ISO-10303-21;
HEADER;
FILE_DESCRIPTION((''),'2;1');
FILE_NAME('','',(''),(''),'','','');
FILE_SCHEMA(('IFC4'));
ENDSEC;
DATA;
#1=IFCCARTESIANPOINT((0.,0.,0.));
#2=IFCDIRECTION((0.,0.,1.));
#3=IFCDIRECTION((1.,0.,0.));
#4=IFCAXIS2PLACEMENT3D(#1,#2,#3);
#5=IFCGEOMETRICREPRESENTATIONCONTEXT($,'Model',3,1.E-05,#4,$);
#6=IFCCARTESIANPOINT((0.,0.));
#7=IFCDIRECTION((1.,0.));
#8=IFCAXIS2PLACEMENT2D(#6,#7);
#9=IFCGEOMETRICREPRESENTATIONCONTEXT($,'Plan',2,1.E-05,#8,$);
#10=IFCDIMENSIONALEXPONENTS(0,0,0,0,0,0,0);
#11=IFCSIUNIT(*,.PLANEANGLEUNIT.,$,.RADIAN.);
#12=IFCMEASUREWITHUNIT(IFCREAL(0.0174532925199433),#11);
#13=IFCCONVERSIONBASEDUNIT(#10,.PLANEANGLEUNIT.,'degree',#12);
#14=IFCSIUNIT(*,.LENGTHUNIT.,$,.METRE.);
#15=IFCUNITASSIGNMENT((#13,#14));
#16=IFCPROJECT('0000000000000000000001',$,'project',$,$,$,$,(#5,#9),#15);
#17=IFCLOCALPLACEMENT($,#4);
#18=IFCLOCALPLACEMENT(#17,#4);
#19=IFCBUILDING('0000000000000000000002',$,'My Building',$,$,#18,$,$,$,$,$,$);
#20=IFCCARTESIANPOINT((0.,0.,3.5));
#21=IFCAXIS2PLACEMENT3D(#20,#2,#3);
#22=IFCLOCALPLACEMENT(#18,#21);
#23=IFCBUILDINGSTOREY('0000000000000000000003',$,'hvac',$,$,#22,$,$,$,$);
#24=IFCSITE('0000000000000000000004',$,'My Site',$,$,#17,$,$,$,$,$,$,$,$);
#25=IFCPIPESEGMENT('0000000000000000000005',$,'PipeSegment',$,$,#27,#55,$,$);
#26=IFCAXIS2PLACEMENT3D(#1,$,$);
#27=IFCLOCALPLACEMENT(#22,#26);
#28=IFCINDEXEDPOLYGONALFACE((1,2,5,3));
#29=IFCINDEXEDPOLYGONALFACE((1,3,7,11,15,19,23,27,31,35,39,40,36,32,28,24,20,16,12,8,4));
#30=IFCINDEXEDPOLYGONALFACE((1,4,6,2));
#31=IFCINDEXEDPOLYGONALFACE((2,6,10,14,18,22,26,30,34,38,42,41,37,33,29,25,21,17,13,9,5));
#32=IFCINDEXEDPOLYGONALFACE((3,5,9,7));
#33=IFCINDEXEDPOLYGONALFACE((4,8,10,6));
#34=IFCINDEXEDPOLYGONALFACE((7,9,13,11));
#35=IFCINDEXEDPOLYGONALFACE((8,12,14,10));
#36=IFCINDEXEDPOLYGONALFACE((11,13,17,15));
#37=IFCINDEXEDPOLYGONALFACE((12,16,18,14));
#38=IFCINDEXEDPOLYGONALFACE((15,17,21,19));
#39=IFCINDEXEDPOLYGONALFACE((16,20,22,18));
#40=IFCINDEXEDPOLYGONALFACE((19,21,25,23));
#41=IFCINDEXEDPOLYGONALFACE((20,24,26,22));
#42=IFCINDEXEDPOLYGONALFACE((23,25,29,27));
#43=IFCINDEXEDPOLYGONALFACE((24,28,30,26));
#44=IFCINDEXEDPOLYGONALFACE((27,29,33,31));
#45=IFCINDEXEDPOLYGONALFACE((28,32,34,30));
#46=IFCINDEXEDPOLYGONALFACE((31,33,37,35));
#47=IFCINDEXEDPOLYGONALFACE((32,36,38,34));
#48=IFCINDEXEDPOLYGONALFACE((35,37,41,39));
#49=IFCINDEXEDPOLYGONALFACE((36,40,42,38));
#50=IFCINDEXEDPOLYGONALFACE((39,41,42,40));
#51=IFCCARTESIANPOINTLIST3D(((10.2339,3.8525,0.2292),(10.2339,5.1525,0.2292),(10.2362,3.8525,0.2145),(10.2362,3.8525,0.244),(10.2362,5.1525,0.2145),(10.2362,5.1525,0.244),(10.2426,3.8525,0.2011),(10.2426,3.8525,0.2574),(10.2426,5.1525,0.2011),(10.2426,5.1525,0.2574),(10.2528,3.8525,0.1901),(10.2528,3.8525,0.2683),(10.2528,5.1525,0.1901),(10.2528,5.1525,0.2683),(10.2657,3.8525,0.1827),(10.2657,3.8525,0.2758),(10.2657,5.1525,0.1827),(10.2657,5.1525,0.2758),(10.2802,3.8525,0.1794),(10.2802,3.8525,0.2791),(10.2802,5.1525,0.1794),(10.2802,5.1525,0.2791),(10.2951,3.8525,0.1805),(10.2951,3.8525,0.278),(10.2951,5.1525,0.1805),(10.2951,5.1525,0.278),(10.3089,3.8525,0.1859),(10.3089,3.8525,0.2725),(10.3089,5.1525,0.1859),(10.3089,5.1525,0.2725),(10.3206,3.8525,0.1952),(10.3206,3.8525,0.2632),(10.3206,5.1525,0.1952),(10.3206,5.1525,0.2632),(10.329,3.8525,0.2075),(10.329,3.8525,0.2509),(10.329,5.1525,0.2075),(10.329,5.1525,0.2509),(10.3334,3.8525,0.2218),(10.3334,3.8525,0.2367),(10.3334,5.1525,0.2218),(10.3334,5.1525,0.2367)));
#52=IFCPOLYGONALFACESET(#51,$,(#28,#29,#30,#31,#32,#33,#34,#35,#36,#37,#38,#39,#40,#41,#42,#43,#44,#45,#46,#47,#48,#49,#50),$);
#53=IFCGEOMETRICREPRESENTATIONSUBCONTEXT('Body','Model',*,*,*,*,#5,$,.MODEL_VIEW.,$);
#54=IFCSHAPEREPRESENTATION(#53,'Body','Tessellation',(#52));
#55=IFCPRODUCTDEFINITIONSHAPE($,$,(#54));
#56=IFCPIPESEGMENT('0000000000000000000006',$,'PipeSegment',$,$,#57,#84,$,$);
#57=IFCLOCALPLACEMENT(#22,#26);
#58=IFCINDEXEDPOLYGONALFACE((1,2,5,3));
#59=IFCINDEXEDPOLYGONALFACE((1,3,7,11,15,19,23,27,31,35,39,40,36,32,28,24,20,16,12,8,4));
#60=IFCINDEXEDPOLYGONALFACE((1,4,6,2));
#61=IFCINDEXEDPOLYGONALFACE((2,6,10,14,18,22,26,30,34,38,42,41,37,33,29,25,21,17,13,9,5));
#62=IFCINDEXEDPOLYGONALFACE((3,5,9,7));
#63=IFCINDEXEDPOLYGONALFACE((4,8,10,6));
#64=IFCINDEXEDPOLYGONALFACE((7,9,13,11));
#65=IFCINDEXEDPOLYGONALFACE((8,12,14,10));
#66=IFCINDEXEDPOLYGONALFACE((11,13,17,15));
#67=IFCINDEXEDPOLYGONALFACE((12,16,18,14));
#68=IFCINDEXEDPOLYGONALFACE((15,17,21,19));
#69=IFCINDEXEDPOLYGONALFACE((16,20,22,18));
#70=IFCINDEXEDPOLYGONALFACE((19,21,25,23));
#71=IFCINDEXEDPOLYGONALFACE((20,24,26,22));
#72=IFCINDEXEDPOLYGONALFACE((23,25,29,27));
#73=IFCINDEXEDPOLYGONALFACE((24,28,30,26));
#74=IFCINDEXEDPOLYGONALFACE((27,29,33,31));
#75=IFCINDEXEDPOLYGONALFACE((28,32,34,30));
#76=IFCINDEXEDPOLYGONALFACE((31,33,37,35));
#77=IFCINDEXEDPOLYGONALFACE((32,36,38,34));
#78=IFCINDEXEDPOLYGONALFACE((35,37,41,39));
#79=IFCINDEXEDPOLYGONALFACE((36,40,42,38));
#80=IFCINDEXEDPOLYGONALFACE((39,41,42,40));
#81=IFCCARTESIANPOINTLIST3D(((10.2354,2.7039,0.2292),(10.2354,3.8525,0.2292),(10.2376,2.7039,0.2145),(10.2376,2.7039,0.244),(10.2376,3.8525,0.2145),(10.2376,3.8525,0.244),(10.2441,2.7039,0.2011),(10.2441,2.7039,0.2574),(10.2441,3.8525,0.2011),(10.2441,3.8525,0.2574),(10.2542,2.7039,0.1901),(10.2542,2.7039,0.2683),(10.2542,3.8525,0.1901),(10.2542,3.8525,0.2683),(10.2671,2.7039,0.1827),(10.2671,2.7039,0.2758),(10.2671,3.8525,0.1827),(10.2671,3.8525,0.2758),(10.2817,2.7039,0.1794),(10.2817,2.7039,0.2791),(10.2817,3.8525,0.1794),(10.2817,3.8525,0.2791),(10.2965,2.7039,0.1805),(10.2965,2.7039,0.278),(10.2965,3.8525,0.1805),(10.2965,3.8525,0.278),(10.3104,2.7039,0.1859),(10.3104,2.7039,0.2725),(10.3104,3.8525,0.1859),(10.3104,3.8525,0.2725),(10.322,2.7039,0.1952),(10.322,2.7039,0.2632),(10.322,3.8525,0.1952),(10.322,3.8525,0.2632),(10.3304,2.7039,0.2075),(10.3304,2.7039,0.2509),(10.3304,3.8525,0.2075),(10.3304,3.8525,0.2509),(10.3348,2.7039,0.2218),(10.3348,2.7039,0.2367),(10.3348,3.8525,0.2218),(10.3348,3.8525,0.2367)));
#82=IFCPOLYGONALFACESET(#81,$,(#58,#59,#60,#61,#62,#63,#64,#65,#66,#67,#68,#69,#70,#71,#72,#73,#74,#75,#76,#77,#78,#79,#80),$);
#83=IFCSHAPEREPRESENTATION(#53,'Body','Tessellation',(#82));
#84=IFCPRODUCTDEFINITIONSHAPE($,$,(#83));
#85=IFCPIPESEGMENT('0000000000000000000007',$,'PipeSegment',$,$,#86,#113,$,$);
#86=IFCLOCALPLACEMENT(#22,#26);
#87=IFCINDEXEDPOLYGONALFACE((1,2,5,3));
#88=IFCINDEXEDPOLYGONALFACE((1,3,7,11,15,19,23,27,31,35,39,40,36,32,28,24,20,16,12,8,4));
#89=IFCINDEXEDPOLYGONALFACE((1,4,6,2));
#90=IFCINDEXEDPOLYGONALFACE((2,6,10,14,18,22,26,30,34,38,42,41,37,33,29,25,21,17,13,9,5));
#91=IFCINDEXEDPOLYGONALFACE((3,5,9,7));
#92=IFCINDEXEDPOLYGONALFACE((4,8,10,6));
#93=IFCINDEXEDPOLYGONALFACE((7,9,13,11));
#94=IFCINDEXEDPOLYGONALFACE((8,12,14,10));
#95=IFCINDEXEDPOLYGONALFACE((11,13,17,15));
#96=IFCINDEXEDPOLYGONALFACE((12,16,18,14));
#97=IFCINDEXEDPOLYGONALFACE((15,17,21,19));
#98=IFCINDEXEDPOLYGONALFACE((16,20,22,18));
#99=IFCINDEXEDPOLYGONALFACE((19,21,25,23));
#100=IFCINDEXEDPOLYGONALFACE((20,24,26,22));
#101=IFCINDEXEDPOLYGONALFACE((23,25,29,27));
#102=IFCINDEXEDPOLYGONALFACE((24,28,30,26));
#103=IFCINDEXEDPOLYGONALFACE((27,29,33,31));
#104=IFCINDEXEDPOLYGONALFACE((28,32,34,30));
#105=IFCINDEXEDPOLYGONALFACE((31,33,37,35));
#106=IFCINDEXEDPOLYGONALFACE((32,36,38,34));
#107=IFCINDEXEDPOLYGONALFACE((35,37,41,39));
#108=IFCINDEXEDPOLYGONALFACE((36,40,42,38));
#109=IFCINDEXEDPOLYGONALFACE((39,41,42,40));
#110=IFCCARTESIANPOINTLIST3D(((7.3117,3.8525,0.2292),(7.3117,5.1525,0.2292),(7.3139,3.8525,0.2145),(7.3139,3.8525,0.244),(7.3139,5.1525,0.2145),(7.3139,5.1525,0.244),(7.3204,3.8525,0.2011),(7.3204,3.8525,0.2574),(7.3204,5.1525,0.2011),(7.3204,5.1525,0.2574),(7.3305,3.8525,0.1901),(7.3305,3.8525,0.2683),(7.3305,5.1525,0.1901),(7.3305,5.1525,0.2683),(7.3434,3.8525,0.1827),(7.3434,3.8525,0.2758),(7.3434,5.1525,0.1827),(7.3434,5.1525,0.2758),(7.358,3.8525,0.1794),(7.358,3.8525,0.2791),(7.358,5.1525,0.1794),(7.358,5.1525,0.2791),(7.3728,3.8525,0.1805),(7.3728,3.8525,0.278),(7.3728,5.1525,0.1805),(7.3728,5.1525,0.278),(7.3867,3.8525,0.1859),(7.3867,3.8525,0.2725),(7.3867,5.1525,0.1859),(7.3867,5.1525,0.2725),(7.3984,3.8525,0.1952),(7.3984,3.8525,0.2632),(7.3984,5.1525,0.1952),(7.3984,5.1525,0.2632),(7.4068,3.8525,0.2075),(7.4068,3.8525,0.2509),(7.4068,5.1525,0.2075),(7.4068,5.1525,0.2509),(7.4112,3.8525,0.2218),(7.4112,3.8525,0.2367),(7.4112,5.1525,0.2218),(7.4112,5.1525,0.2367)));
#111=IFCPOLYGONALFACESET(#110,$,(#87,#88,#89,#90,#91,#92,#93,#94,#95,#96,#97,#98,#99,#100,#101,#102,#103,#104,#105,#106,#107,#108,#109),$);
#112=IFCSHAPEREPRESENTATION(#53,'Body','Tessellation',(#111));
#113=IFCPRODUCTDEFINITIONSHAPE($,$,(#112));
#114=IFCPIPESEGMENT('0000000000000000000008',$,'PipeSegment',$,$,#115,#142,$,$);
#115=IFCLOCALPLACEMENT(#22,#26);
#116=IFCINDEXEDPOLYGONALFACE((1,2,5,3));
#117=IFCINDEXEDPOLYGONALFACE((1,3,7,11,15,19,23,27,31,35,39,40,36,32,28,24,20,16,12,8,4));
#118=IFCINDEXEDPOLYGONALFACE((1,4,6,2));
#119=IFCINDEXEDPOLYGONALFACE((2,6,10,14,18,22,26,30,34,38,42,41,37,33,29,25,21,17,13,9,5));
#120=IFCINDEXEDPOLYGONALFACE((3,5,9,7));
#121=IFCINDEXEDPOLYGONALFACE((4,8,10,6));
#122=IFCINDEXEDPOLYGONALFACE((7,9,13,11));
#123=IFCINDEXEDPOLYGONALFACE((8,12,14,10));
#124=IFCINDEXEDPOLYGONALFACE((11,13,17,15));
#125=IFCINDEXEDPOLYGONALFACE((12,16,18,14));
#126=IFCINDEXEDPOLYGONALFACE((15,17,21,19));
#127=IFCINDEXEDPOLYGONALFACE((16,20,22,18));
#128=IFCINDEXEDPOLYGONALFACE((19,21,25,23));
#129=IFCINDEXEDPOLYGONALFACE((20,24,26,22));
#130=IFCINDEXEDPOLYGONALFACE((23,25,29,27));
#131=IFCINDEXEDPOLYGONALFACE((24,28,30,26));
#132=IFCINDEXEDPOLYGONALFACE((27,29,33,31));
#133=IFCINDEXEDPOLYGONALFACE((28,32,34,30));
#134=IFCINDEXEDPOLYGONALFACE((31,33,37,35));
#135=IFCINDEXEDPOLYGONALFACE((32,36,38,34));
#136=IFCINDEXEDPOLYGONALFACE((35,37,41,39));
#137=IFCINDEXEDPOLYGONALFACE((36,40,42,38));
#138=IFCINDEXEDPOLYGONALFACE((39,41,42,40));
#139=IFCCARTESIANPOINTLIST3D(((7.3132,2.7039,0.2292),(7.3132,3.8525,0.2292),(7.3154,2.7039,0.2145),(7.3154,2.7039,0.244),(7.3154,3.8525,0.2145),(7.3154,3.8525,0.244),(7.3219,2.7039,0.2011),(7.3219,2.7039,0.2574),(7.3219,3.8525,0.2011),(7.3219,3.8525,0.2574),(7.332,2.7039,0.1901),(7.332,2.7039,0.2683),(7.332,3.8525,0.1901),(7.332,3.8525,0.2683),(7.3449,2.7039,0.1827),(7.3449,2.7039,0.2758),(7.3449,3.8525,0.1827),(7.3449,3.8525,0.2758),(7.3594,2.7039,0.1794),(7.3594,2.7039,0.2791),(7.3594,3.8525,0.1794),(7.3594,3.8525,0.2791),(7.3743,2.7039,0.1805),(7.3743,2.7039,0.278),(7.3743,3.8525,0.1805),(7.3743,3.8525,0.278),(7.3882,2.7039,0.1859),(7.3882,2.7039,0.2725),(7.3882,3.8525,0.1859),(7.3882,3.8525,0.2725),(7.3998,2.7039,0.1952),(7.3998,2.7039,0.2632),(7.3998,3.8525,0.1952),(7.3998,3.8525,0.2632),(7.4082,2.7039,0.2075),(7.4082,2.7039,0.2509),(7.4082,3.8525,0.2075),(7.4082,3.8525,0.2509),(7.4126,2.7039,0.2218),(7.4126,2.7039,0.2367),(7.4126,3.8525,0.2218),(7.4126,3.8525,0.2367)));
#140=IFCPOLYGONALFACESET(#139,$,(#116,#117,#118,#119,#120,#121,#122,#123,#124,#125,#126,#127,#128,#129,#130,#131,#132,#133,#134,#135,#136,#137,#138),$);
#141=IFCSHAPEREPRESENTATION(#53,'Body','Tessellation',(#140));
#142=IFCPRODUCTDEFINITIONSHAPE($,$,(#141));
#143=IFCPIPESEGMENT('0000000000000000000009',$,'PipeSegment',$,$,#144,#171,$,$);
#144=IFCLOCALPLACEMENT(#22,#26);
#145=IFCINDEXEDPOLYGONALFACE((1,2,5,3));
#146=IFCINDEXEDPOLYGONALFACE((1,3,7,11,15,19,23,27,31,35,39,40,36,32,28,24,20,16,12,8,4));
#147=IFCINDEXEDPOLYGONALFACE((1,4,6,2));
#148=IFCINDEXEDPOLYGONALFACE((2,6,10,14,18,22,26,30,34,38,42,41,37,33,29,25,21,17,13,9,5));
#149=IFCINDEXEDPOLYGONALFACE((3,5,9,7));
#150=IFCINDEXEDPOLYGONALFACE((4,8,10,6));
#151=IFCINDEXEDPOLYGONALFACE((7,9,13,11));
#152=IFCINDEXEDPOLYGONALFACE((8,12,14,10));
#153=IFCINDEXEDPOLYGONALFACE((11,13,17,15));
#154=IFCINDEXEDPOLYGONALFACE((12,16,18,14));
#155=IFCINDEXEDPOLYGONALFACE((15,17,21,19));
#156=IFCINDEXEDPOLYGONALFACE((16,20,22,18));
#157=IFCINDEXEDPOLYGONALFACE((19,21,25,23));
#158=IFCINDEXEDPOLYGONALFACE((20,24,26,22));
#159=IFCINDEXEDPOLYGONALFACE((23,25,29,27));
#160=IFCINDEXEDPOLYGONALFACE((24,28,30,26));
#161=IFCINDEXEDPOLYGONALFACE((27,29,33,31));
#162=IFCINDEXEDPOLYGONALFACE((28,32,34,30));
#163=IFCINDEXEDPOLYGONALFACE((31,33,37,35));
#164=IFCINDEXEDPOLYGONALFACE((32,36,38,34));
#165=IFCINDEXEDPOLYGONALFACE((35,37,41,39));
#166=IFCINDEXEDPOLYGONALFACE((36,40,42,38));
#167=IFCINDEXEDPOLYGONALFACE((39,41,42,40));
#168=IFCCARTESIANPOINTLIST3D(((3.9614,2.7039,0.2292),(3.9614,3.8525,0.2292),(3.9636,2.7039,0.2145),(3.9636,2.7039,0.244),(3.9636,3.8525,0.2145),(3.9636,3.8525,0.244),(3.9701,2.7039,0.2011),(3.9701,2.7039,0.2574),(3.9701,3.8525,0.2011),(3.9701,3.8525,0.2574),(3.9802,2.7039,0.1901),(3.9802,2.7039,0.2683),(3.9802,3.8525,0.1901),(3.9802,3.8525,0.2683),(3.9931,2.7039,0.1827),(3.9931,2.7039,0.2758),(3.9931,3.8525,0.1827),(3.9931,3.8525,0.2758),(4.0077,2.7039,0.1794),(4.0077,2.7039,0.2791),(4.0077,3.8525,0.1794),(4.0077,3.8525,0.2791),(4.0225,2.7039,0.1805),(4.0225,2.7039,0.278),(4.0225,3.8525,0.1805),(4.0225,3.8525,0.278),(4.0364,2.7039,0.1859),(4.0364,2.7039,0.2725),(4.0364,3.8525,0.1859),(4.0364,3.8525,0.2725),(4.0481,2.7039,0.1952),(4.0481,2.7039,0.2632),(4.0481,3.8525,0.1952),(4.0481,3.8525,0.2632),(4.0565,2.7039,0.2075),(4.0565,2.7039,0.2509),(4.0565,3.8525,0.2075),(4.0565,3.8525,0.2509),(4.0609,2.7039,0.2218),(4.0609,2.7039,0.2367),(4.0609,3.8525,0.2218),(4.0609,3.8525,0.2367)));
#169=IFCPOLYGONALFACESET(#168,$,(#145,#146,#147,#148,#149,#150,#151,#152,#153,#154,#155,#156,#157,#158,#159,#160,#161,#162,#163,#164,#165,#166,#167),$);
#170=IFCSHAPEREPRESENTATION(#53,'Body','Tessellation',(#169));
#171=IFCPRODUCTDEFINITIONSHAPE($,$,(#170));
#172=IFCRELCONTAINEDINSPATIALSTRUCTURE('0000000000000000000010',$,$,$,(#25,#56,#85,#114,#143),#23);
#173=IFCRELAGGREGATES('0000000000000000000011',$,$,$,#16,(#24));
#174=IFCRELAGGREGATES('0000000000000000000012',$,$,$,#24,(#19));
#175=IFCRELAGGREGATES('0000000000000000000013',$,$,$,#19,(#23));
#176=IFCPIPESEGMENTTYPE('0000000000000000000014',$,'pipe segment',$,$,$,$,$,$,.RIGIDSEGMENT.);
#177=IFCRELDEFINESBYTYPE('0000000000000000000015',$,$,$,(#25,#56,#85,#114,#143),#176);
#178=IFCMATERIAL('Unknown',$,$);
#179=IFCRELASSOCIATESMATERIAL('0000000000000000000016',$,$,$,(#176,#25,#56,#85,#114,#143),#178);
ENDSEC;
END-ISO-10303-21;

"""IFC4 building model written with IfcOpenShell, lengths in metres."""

from ifc_helpers import new_model, entity, si_unit, converted_unit, frame, origin_with_axes, origin_2d_with_axis, place, context, subcontext, project, spatial, circle, extrude, material, material_profile, profile_set, profile_usage, type_object, element, save


model = new_model("IFC4")

# Units and contexts
model_context = context("Model", 3, precision=1e-05, world=origin_with_axes())
plan_context = context("Plan", 2, precision=1e-05, world=origin_2d_with_axis())
body_context_1 = subcontext(model_context, "Body", "Model", "MODEL_VIEW")
ifc_project = project(units=[converted_unit("PLANEANGLEUNIT", "degree", entity("IfcReal", 0.0174532925199433), si_unit("PLANEANGLEUNIT", "RADIAN"), dimensions=[0, 0, 0, 0, 0, 0, 0]), si_unit("LENGTHUNIT", "METRE")], contexts=[model_context, plan_context])

# Site, building, storey
site_placement = place(None, origin_with_axes())
site = spatial("IfcSite", under=ifc_project, at=site_placement, Name="My Site")
building_placement = place(site_placement, origin_with_axes())
building = spatial("IfcBuilding", under=site, at=building_placement, Name="My Building")
storey_placement = place(building_placement, frame((0.0, 0.0, 3.5), z_axis=(0.0, 0.0, 1.0), x_axis=(1.0, 0.0, 0.0)))
storey = spatial("IfcBuildingStorey", under=building, at=storey_placement, Name="hvac")

# Shared definitions
ifc_material = material(Name="Unknown")

# Pipe segments
ifc_material_profile_1 = material_profile(ifc_material, circle(Radius=0.05))
ifc_profile_set_1 = profile_set([ifc_material_profile_1])
ifc_profile_usage_1 = profile_usage(ifc_profile_set_1, cardinal=5)
pipe_segment_type = type_object("IfcPipeSegmentType", Name="pipe segment", PredefinedType="RIGIDSEGMENT", material=ifc_profile_set_1)
pipe_segment_1_placement = place(storey_placement, frame((10.2839, 3.8525, 0.2292), z_axis=(0.0, 1.0, 0.0), x_axis=(-1.0, 0.0, 0.0)))
element("IfcPipeSegment", 1, at=pipe_segment_1_placement, inside=storey, type_object=pipe_segment_type, material=ifc_profile_usage_1, Name="PipeSegment", context=body_context_1, shape_type="SweptSolid", body=[
    extrude(circle(Radius=0.05), origin_with_axes(), (0.0, 0.0, 1.0), 1.3),
])
ifc_profile_usage_2 = profile_usage(ifc_profile_set_1, cardinal=5)
pipe_segment_2_placement = place(storey_placement, frame((10.2854, 2.7039, 0.2292), z_axis=(0.0, 1.0, 0.0), x_axis=(-1.0, 0.0, 0.0)))
element("IfcPipeSegment", 2, at=pipe_segment_2_placement, inside=storey, type_object=pipe_segment_type, material=ifc_profile_usage_2, Name="PipeSegment", context=body_context_1, shape_type="SweptSolid", body=[
    extrude(circle(Radius=0.05), origin_with_axes(), (0.0, 0.0, 1.0), 1.1486),
])
ifc_profile_usage_3 = profile_usage(ifc_profile_set_1, cardinal=5)
pipe_segment_3_placement = place(storey_placement, frame((7.3617, 3.8525, 0.2292), z_axis=(0.0, 1.0, 0.0), x_axis=(-1.0, 0.0, 0.0)))
element("IfcPipeSegment", 3, at=pipe_segment_3_placement, inside=storey, type_object=pipe_segment_type, material=ifc_profile_usage_3, Name="PipeSegment", context=body_context_1, shape_type="SweptSolid", body=[
    extrude(circle(Radius=0.05), origin_with_axes(), (0.0, 0.0, 1.0), 1.3),
])
ifc_profile_usage_4 = profile_usage(ifc_profile_set_1, cardinal=5)
pipe_segment_4_placement = place(storey_placement, frame((7.3632, 2.7039, 0.2292), z_axis=(0.0, 1.0, 0.0), x_axis=(-1.0, 0.0, 0.0)))
element("IfcPipeSegment", 4, at=pipe_segment_4_placement, inside=storey, type_object=pipe_segment_type, material=ifc_profile_usage_4, Name="PipeSegment", context=body_context_1, shape_type="SweptSolid", body=[
    extrude(circle(Radius=0.05), origin_with_axes(), (0.0, 0.0, 1.0), 1.1486),
])
ifc_profile_usage_5 = profile_usage(ifc_profile_set_1, cardinal=5)
pipe_segment_5_placement = place(storey_placement, frame((4.0114, 2.7039, 0.2292), z_axis=(0.0, 1.0, 0.0), x_axis=(-1.0, 0.0, 0.0)))
element("IfcPipeSegment", 5, at=pipe_segment_5_placement, inside=storey, type_object=pipe_segment_type, material=ifc_profile_usage_5, Name="PipeSegment", context=body_context_1, shape_type="SweptSolid", body=[
    extrude(circle(Radius=0.05), origin_with_axes(), (0.0, 0.0, 1.0), 1.1486),
])

save(model, "model.ifc")
